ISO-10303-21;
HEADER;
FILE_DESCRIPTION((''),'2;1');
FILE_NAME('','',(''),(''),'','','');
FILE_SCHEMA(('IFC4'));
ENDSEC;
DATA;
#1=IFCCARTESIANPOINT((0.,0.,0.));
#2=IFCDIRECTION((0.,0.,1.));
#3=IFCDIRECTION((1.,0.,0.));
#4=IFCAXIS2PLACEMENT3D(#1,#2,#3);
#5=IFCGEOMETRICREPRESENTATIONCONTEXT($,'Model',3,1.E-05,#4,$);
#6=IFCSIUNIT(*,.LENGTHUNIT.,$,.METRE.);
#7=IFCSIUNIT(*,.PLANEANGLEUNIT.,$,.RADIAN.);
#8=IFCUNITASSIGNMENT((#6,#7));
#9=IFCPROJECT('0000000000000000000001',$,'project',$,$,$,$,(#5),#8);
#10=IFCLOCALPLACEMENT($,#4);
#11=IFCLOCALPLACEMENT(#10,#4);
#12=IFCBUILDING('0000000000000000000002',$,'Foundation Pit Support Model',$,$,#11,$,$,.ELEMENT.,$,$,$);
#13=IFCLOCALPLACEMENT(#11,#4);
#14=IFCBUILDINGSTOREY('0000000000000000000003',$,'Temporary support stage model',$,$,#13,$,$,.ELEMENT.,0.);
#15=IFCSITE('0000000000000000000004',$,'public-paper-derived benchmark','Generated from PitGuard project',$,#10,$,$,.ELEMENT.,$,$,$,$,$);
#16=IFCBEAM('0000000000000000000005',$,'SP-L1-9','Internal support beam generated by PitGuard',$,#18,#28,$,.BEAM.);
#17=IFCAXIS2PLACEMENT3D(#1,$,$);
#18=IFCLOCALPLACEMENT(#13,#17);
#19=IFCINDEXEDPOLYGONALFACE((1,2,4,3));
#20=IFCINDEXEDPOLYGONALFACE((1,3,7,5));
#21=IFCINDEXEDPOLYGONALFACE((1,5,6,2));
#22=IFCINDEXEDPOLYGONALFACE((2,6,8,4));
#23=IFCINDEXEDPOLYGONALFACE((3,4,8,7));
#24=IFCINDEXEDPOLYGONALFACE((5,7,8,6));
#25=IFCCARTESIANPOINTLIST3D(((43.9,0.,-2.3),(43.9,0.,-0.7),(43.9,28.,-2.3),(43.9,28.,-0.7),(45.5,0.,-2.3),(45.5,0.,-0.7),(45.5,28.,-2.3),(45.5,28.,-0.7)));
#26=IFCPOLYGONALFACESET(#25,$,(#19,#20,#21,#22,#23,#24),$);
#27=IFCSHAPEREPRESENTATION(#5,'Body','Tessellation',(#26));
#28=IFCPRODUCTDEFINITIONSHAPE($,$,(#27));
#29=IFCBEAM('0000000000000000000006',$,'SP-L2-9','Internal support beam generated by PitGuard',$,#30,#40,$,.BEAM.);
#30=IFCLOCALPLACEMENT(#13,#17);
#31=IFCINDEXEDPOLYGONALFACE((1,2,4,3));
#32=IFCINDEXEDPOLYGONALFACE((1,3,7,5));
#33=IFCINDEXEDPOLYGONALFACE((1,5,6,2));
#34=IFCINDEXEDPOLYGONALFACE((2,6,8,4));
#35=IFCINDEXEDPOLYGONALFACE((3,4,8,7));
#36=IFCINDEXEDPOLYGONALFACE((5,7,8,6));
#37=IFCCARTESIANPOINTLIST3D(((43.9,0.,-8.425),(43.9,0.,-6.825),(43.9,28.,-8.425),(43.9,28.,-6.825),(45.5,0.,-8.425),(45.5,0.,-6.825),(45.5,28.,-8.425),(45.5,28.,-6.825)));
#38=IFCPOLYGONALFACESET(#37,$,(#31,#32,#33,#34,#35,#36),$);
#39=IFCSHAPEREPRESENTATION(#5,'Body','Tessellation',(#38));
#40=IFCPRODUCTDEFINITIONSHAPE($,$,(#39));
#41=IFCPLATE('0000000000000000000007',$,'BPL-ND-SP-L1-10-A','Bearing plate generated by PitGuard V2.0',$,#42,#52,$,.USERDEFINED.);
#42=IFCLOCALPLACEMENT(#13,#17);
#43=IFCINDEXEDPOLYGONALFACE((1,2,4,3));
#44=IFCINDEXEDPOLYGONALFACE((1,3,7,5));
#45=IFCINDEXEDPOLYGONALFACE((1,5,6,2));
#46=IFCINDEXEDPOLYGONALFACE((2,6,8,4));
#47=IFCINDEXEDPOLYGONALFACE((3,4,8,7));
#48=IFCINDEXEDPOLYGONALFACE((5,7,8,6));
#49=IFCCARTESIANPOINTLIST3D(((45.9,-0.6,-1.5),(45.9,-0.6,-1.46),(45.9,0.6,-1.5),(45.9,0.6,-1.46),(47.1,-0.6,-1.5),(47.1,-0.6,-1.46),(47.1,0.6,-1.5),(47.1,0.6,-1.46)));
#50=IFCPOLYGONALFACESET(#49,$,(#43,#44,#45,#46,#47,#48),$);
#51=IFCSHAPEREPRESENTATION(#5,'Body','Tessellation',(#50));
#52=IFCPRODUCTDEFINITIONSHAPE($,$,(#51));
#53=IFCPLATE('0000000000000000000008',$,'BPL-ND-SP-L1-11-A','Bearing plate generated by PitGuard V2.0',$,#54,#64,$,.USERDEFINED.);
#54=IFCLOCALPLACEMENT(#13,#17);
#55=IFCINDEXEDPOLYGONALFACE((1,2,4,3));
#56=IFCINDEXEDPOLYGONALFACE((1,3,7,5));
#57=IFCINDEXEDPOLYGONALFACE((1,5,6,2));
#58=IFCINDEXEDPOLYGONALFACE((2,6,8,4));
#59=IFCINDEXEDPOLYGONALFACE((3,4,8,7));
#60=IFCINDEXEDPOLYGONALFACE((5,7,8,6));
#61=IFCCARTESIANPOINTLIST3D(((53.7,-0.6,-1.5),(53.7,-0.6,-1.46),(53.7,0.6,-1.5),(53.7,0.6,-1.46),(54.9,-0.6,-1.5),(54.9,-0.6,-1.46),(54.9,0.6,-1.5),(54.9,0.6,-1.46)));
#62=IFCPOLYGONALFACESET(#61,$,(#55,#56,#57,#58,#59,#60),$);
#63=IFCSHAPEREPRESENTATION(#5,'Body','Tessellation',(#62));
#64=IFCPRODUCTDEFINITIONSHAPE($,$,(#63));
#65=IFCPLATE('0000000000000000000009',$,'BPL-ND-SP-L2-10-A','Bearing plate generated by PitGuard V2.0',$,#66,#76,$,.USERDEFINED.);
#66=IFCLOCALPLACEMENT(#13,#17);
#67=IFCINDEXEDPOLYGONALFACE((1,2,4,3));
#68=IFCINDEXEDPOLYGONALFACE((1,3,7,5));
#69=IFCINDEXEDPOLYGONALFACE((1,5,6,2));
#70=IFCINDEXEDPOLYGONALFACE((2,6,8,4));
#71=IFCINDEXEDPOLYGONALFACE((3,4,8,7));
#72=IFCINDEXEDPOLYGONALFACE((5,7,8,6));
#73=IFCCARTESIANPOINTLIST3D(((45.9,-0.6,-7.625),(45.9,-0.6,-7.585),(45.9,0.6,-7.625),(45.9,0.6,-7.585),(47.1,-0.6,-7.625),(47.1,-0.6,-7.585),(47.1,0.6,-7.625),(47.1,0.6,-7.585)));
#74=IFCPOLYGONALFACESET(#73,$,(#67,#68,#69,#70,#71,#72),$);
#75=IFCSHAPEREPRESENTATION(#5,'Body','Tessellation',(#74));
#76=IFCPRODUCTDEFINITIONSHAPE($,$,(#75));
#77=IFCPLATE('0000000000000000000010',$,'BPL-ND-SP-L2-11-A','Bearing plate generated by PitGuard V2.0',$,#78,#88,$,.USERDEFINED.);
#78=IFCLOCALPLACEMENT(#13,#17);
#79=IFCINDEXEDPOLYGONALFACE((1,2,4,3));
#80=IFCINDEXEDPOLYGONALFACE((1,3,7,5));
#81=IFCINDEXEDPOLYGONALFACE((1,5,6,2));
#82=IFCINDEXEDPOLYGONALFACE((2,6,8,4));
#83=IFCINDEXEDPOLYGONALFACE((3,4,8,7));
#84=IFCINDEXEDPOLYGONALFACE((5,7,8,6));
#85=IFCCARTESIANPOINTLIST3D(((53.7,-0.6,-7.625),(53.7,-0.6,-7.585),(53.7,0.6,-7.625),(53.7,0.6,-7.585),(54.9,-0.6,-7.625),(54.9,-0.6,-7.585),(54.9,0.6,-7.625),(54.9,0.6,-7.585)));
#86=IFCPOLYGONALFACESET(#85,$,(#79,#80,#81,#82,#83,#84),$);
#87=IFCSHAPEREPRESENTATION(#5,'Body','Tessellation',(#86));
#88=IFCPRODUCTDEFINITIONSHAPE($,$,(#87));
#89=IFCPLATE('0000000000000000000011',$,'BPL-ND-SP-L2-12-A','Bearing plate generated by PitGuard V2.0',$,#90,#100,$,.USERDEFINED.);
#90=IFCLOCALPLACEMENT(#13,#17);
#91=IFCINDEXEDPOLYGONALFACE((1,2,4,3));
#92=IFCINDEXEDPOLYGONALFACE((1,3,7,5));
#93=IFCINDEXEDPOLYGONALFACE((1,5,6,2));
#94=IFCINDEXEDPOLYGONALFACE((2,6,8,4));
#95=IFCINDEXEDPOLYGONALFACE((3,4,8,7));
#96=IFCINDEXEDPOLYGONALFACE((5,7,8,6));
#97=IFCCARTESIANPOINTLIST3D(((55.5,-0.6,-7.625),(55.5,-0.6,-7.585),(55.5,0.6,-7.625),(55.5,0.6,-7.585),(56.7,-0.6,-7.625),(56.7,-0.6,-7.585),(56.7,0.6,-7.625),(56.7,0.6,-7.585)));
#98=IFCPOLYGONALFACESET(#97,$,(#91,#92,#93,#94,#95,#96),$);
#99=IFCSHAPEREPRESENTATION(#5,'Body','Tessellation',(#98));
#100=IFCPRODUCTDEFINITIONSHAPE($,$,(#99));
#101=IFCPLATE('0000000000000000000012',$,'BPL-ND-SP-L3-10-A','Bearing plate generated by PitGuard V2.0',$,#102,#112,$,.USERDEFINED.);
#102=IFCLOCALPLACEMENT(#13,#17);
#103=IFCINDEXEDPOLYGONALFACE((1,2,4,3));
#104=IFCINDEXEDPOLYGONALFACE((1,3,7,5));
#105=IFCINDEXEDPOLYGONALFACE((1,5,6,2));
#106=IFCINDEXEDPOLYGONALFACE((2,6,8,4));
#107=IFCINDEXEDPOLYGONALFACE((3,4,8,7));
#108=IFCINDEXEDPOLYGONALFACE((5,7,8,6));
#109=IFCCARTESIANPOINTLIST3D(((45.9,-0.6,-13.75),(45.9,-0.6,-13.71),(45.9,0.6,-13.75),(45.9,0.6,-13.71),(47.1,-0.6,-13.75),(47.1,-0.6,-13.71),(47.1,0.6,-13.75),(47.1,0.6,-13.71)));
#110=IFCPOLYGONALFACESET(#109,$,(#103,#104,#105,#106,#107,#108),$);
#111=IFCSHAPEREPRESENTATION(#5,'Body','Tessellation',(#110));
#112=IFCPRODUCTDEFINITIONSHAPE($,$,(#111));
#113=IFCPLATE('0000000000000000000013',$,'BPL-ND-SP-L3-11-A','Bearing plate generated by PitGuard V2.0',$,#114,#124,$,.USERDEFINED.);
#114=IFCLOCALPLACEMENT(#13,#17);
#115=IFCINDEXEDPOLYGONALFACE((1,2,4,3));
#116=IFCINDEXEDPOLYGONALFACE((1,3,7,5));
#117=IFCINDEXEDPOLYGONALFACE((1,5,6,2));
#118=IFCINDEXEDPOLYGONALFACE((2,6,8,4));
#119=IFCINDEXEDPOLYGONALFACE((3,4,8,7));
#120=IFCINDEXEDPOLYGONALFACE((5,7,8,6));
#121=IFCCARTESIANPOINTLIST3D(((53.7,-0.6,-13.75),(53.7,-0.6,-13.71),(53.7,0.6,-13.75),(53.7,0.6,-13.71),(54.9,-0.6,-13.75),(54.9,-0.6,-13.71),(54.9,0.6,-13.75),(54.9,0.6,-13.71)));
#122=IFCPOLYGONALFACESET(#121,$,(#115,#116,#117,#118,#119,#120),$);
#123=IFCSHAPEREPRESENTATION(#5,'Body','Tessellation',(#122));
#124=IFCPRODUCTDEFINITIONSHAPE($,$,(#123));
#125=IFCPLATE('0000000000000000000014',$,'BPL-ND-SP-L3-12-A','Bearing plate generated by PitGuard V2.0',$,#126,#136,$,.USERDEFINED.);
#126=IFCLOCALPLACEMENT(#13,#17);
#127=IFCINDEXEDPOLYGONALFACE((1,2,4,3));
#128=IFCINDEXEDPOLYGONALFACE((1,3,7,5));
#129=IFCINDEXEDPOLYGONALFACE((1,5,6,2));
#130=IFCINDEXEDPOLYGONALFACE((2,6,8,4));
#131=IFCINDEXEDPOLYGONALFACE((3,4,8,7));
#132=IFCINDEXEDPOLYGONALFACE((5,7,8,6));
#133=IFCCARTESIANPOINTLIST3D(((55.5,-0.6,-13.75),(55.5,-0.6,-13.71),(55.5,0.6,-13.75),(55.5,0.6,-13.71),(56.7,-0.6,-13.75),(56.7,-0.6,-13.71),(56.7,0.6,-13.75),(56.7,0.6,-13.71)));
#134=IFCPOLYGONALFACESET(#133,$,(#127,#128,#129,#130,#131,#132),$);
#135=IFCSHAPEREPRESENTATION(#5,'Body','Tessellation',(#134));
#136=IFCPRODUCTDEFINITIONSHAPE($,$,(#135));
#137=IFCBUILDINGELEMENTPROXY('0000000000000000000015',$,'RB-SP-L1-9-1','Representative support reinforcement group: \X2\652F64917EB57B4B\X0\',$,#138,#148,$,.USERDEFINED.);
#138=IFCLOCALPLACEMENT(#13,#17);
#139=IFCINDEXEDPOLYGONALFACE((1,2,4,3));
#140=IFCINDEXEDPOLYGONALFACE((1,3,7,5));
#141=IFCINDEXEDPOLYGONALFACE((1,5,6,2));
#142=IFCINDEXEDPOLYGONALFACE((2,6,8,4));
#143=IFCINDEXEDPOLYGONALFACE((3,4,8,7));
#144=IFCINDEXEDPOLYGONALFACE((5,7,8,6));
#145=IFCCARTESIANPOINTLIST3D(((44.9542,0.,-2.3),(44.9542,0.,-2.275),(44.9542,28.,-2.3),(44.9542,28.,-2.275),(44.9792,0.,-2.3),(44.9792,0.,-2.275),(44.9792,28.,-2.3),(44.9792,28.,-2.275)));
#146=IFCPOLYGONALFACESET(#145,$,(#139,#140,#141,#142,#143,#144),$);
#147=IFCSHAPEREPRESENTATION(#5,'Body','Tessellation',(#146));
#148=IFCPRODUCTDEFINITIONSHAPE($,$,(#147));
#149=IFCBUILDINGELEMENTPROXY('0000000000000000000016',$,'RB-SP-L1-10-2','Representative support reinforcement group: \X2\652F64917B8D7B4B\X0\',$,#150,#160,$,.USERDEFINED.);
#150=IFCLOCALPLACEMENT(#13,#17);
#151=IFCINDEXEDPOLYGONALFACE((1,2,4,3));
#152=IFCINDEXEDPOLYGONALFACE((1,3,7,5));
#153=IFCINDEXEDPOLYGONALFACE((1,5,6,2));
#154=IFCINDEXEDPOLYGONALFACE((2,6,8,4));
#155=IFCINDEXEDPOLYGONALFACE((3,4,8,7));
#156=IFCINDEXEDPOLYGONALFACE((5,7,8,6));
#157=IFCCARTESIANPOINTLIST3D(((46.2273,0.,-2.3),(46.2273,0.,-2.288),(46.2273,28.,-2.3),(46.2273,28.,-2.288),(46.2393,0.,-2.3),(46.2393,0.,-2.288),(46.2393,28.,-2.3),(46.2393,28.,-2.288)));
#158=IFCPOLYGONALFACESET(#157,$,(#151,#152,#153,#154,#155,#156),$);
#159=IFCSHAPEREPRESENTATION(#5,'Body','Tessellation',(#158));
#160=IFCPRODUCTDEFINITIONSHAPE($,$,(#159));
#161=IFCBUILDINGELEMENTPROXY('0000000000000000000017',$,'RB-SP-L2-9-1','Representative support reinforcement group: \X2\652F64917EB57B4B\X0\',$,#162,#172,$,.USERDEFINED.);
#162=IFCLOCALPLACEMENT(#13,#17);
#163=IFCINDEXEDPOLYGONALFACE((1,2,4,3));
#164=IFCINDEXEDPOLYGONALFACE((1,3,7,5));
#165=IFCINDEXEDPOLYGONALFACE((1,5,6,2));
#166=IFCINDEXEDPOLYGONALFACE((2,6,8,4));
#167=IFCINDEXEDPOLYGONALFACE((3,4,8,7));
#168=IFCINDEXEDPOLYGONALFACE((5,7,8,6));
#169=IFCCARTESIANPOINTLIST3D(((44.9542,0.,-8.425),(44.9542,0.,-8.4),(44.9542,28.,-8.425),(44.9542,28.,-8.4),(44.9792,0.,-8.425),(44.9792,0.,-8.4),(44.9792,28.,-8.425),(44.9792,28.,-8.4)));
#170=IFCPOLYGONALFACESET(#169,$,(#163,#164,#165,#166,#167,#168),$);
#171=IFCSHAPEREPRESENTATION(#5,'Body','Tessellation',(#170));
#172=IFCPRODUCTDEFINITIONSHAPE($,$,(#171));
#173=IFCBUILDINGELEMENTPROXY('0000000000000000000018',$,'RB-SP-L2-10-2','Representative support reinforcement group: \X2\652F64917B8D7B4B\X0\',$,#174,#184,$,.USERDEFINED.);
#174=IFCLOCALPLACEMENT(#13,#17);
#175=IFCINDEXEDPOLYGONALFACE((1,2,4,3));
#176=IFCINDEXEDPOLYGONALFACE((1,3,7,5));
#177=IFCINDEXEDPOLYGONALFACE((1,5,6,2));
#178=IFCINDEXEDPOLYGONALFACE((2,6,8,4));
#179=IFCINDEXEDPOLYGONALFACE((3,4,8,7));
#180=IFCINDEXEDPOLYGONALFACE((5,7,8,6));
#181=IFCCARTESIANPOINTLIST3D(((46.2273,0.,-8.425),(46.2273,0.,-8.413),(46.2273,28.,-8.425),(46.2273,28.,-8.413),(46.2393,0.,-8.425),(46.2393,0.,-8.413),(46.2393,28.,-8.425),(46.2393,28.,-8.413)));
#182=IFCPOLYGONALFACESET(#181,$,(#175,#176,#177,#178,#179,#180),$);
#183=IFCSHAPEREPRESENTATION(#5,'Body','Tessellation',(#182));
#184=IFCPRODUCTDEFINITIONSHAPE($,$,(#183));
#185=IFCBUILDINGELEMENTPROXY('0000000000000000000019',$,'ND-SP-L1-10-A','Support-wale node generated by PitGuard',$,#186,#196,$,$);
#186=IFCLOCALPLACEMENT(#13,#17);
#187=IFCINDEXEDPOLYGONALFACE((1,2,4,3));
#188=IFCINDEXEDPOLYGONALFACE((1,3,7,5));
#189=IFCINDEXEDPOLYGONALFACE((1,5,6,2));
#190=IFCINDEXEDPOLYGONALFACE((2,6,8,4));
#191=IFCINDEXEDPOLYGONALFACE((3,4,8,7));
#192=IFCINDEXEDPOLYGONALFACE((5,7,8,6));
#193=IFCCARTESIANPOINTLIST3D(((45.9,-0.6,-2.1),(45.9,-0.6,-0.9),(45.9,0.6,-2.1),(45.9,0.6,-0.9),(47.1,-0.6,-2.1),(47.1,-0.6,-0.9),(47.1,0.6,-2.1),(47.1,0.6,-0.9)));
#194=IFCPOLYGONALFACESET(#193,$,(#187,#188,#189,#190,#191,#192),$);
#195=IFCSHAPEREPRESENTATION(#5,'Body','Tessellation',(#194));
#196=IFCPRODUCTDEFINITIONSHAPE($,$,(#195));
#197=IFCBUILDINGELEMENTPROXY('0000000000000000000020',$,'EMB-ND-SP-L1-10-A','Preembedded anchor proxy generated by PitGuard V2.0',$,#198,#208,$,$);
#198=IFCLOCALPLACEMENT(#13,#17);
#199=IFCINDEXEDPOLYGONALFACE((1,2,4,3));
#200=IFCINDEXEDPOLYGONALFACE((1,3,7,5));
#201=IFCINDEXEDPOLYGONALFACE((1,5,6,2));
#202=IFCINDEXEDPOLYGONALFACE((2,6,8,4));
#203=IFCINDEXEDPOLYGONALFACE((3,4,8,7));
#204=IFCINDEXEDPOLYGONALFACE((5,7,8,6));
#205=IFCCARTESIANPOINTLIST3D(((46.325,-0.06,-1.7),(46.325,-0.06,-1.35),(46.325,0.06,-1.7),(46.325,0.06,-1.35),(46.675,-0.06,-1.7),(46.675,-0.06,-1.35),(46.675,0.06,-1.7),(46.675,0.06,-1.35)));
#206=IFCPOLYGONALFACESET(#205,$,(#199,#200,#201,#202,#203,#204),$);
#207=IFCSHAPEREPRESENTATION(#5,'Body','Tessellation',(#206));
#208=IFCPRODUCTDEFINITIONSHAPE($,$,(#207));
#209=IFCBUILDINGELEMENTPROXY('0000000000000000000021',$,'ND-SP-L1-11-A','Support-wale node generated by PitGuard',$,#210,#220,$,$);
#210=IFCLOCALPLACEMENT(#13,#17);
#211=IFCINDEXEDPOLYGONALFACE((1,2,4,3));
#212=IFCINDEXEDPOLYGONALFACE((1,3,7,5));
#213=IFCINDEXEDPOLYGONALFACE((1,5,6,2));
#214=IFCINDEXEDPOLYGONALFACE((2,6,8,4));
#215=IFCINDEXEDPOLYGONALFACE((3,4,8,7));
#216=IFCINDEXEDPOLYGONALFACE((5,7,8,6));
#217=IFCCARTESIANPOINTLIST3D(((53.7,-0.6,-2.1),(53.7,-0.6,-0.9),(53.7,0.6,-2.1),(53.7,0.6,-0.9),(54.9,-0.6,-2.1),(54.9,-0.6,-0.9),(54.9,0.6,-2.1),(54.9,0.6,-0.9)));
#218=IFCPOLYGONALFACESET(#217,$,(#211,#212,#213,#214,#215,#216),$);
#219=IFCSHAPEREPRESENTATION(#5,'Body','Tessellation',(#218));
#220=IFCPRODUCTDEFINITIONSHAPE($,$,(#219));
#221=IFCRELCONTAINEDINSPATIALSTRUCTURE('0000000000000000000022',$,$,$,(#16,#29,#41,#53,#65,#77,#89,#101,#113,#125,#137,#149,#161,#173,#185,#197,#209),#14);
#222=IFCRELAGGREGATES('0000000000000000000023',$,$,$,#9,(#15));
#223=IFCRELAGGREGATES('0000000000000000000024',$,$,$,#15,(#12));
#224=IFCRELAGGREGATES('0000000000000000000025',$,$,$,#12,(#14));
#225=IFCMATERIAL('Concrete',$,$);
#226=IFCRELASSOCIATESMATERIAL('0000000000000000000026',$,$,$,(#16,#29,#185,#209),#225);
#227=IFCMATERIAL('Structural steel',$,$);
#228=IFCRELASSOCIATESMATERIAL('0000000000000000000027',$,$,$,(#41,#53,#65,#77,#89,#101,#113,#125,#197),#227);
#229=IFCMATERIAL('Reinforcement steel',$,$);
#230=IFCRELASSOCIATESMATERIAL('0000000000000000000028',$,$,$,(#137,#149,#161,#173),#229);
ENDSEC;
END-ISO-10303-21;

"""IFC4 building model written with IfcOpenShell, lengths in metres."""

from ifc_helpers import new_model, si_unit, frame, origin_with_axes, origin_2d, place, context, project, spatial, rectangle, extrude, material, element, save


model = new_model("IFC4")

# Units and contexts
model_context = context("Model", 3, precision=1e-05, world=origin_with_axes())
ifc_project = project(units=[si_unit("LENGTHUNIT", "METRE"), si_unit("PLANEANGLEUNIT", "RADIAN")], contexts=[model_context])

# Site, building, storey
site_placement = place(None, origin_with_axes())
site = spatial("IfcSite", under=ifc_project, at=site_placement, Name="public-paper-derived benchmark", Description="Generated from PitGuard project", CompositionType="ELEMENT")
building_placement = place(site_placement, origin_with_axes())
building = spatial("IfcBuilding", under=site, at=building_placement, Name="Foundation Pit Support Model", CompositionType="ELEMENT")
storey_placement = place(building_placement, origin_with_axes())
storey = spatial("IfcBuildingStorey", under=building, at=storey_placement, Name="Temporary support stage model", CompositionType="ELEMENT", Elevation=0.0)

# Beams
ifc_material_1 = material(Name="Concrete")
for number, where, z_axis, x_axis, name in (
    (1, (44.7, 14.0, -2.3), (0.0, 0.0, 1.0), (0.0, 1.0, 0.0), "SP-L1-9"),
    (2, (44.7, 14.0, -8.425), (0.0, 0.0, 1.0), (0.0, 1.0, 0.0), "SP-L2-9"),
):
    element("IfcBeam", number, at=place(storey_placement, frame(where, z_axis=z_axis, x_axis=x_axis)), inside=storey, material=ifc_material_1, Name=name, Description="Internal support beam generated by PitGuard", PredefinedType="BEAM", context=model_context, shape_type="SweptSolid", body=[
        extrude(rectangle(XDim=28.0, YDim=1.6, at=origin_2d()), origin_with_axes(), (0.0, 0.0, 1.0), 1.6),
    ])

# Plates
ifc_material_2 = material(Name="Structural steel")
for number, where, z_axis, x_axis, name in (
    (3, (46.5, 0.0, -1.5), (0.0, 0.0, 1.0), (1.0, 0.0, 0.0), "BPL-ND-SP-L1-10-A"),
    (4, (54.3, 0.0, -1.5), (0.0, 0.0, 1.0), (1.0, 0.0, 0.0), "BPL-ND-SP-L1-11-A"),
    (5, (46.5, 0.0, -7.625), (0.0, 0.0, 1.0), (1.0, 0.0, 0.0), "BPL-ND-SP-L2-10-A"),
    (6, (54.3, 0.0, -7.625), (0.0, 0.0, 1.0), (1.0, 0.0, 0.0), "BPL-ND-SP-L2-11-A"),
    (7, (56.1, 0.0, -7.625), (0.0, 0.0, 1.0), (1.0, 0.0, 0.0), "BPL-ND-SP-L2-12-A"),
    (8, (46.5, 0.0, -13.75), (0.0, 0.0, 1.0), (1.0, 0.0, 0.0), "BPL-ND-SP-L3-10-A"),
    (9, (54.3, 0.0, -13.75), (0.0, 0.0, 1.0), (1.0, 0.0, 0.0), "BPL-ND-SP-L3-11-A"),
    (10, (56.1, 0.0, -13.75), (0.0, 0.0, 1.0), (1.0, 0.0, 0.0), "BPL-ND-SP-L3-12-A"),
):
    element("IfcPlate", number, at=place(storey_placement, frame(where, z_axis=z_axis, x_axis=x_axis)), inside=storey, material=ifc_material_2, Name=name, Description="Bearing plate generated by PitGuard V2.0", PredefinedType="USERDEFINED", context=model_context, shape_type="SweptSolid", body=[
        extrude(rectangle(XDim=1.2, YDim=1.2, at=origin_2d()), origin_with_axes(), (0.0, 0.0, 1.0), 0.04),
    ])

# Building element proxies
ifc_material_3 = material(Name="Reinforcement steel")
proxy_1_placement = place(storey_placement, frame((44.9667, 14.0, -2.3), z_axis=(0.0, 0.0, 1.0), x_axis=(0.0, 1.0, 0.0)))
element("IfcBuildingElementProxy", 11, at=proxy_1_placement, inside=storey, material=ifc_material_3, Name="RB-SP-L1-9-1", Description="Representative support reinforcement group: 支撑纵筋", PredefinedType="USERDEFINED", context=model_context, shape_type="SweptSolid", body=[
    extrude(rectangle(XDim=28.0, YDim=0.025, at=origin_2d()), origin_with_axes(), (0.0, 0.0, 1.0), 0.025),
])
proxy_2_placement = place(storey_placement, frame((46.2333, 14.0, -2.3), z_axis=(0.0, 0.0, 1.0), x_axis=(0.0, 1.0, 0.0)))
element("IfcBuildingElementProxy", 12, at=proxy_2_placement, inside=storey, material=ifc_material_3, Name="RB-SP-L1-10-2", Description="Representative support reinforcement group: 支撑箍筋", PredefinedType="USERDEFINED", context=model_context, shape_type="SweptSolid", body=[
    extrude(rectangle(XDim=28.0, YDim=0.012, at=origin_2d()), origin_with_axes(), (0.0, 0.0, 1.0), 0.012),
])
proxy_3_placement = place(storey_placement, frame((44.9667, 14.0, -8.425), z_axis=(0.0, 0.0, 1.0), x_axis=(0.0, 1.0, 0.0)))
element("IfcBuildingElementProxy", 13, at=proxy_3_placement, inside=storey, material=ifc_material_3, Name="RB-SP-L2-9-1", Description="Representative support reinforcement group: 支撑纵筋", PredefinedType="USERDEFINED", context=model_context, shape_type="SweptSolid", body=[
    extrude(rectangle(XDim=28.0, YDim=0.025, at=origin_2d()), origin_with_axes(), (0.0, 0.0, 1.0), 0.025),
])
proxy_4_placement = place(storey_placement, frame((46.2333, 14.0, -8.425), z_axis=(0.0, 0.0, 1.0), x_axis=(0.0, 1.0, 0.0)))
element("IfcBuildingElementProxy", 14, at=proxy_4_placement, inside=storey, material=ifc_material_3, Name="RB-SP-L2-10-2", Description="Representative support reinforcement group: 支撑箍筋", PredefinedType="USERDEFINED", context=model_context, shape_type="SweptSolid", body=[
    extrude(rectangle(XDim=28.0, YDim=0.012, at=origin_2d()), origin_with_axes(), (0.0, 0.0, 1.0), 0.012),
])
proxy_5_placement = place(storey_placement, frame((46.5, 0.0, -2.1), z_axis=(0.0, 0.0, 1.0), x_axis=(1.0, 0.0, 0.0)))
element("IfcBuildingElementProxy", 15, at=proxy_5_placement, inside=storey, material=ifc_material_1, Name="ND-SP-L1-10-A", Description="Support-wale node generated by PitGuard", context=model_context, shape_type="SweptSolid", body=[
    extrude(rectangle(XDim=1.2, YDim=1.2, at=origin_2d()), origin_with_axes(), (0.0, 0.0, 1.0), 1.2),
])
proxy_6_placement = place(storey_placement, frame((46.5, 0.0, -1.7), z_axis=(0.0, 0.0, 1.0), x_axis=(1.0, 0.0, 0.0)))
element("IfcBuildingElementProxy", 16, at=proxy_6_placement, inside=storey, material=ifc_material_2, Name="EMB-ND-SP-L1-10-A", Description="Preembedded anchor proxy generated by PitGuard V2.0", context=model_context, shape_type="SweptSolid", body=[
    extrude(rectangle(XDim=0.35, YDim=0.12, at=origin_2d()), origin_with_axes(), (0.0, 0.0, 1.0), 0.35),
])
proxy_7_placement = place(storey_placement, frame((54.3, 0.0, -2.1), z_axis=(0.0, 0.0, 1.0), x_axis=(1.0, 0.0, 0.0)))
element("IfcBuildingElementProxy", 17, at=proxy_7_placement, inside=storey, material=ifc_material_1, Name="ND-SP-L1-11-A", Description="Support-wale node generated by PitGuard", context=model_context, shape_type="SweptSolid", body=[
    extrude(rectangle(XDim=1.2, YDim=1.2, at=origin_2d()), origin_with_axes(), (0.0, 0.0, 1.0), 1.2),
])

save(model, "model.ifc")
